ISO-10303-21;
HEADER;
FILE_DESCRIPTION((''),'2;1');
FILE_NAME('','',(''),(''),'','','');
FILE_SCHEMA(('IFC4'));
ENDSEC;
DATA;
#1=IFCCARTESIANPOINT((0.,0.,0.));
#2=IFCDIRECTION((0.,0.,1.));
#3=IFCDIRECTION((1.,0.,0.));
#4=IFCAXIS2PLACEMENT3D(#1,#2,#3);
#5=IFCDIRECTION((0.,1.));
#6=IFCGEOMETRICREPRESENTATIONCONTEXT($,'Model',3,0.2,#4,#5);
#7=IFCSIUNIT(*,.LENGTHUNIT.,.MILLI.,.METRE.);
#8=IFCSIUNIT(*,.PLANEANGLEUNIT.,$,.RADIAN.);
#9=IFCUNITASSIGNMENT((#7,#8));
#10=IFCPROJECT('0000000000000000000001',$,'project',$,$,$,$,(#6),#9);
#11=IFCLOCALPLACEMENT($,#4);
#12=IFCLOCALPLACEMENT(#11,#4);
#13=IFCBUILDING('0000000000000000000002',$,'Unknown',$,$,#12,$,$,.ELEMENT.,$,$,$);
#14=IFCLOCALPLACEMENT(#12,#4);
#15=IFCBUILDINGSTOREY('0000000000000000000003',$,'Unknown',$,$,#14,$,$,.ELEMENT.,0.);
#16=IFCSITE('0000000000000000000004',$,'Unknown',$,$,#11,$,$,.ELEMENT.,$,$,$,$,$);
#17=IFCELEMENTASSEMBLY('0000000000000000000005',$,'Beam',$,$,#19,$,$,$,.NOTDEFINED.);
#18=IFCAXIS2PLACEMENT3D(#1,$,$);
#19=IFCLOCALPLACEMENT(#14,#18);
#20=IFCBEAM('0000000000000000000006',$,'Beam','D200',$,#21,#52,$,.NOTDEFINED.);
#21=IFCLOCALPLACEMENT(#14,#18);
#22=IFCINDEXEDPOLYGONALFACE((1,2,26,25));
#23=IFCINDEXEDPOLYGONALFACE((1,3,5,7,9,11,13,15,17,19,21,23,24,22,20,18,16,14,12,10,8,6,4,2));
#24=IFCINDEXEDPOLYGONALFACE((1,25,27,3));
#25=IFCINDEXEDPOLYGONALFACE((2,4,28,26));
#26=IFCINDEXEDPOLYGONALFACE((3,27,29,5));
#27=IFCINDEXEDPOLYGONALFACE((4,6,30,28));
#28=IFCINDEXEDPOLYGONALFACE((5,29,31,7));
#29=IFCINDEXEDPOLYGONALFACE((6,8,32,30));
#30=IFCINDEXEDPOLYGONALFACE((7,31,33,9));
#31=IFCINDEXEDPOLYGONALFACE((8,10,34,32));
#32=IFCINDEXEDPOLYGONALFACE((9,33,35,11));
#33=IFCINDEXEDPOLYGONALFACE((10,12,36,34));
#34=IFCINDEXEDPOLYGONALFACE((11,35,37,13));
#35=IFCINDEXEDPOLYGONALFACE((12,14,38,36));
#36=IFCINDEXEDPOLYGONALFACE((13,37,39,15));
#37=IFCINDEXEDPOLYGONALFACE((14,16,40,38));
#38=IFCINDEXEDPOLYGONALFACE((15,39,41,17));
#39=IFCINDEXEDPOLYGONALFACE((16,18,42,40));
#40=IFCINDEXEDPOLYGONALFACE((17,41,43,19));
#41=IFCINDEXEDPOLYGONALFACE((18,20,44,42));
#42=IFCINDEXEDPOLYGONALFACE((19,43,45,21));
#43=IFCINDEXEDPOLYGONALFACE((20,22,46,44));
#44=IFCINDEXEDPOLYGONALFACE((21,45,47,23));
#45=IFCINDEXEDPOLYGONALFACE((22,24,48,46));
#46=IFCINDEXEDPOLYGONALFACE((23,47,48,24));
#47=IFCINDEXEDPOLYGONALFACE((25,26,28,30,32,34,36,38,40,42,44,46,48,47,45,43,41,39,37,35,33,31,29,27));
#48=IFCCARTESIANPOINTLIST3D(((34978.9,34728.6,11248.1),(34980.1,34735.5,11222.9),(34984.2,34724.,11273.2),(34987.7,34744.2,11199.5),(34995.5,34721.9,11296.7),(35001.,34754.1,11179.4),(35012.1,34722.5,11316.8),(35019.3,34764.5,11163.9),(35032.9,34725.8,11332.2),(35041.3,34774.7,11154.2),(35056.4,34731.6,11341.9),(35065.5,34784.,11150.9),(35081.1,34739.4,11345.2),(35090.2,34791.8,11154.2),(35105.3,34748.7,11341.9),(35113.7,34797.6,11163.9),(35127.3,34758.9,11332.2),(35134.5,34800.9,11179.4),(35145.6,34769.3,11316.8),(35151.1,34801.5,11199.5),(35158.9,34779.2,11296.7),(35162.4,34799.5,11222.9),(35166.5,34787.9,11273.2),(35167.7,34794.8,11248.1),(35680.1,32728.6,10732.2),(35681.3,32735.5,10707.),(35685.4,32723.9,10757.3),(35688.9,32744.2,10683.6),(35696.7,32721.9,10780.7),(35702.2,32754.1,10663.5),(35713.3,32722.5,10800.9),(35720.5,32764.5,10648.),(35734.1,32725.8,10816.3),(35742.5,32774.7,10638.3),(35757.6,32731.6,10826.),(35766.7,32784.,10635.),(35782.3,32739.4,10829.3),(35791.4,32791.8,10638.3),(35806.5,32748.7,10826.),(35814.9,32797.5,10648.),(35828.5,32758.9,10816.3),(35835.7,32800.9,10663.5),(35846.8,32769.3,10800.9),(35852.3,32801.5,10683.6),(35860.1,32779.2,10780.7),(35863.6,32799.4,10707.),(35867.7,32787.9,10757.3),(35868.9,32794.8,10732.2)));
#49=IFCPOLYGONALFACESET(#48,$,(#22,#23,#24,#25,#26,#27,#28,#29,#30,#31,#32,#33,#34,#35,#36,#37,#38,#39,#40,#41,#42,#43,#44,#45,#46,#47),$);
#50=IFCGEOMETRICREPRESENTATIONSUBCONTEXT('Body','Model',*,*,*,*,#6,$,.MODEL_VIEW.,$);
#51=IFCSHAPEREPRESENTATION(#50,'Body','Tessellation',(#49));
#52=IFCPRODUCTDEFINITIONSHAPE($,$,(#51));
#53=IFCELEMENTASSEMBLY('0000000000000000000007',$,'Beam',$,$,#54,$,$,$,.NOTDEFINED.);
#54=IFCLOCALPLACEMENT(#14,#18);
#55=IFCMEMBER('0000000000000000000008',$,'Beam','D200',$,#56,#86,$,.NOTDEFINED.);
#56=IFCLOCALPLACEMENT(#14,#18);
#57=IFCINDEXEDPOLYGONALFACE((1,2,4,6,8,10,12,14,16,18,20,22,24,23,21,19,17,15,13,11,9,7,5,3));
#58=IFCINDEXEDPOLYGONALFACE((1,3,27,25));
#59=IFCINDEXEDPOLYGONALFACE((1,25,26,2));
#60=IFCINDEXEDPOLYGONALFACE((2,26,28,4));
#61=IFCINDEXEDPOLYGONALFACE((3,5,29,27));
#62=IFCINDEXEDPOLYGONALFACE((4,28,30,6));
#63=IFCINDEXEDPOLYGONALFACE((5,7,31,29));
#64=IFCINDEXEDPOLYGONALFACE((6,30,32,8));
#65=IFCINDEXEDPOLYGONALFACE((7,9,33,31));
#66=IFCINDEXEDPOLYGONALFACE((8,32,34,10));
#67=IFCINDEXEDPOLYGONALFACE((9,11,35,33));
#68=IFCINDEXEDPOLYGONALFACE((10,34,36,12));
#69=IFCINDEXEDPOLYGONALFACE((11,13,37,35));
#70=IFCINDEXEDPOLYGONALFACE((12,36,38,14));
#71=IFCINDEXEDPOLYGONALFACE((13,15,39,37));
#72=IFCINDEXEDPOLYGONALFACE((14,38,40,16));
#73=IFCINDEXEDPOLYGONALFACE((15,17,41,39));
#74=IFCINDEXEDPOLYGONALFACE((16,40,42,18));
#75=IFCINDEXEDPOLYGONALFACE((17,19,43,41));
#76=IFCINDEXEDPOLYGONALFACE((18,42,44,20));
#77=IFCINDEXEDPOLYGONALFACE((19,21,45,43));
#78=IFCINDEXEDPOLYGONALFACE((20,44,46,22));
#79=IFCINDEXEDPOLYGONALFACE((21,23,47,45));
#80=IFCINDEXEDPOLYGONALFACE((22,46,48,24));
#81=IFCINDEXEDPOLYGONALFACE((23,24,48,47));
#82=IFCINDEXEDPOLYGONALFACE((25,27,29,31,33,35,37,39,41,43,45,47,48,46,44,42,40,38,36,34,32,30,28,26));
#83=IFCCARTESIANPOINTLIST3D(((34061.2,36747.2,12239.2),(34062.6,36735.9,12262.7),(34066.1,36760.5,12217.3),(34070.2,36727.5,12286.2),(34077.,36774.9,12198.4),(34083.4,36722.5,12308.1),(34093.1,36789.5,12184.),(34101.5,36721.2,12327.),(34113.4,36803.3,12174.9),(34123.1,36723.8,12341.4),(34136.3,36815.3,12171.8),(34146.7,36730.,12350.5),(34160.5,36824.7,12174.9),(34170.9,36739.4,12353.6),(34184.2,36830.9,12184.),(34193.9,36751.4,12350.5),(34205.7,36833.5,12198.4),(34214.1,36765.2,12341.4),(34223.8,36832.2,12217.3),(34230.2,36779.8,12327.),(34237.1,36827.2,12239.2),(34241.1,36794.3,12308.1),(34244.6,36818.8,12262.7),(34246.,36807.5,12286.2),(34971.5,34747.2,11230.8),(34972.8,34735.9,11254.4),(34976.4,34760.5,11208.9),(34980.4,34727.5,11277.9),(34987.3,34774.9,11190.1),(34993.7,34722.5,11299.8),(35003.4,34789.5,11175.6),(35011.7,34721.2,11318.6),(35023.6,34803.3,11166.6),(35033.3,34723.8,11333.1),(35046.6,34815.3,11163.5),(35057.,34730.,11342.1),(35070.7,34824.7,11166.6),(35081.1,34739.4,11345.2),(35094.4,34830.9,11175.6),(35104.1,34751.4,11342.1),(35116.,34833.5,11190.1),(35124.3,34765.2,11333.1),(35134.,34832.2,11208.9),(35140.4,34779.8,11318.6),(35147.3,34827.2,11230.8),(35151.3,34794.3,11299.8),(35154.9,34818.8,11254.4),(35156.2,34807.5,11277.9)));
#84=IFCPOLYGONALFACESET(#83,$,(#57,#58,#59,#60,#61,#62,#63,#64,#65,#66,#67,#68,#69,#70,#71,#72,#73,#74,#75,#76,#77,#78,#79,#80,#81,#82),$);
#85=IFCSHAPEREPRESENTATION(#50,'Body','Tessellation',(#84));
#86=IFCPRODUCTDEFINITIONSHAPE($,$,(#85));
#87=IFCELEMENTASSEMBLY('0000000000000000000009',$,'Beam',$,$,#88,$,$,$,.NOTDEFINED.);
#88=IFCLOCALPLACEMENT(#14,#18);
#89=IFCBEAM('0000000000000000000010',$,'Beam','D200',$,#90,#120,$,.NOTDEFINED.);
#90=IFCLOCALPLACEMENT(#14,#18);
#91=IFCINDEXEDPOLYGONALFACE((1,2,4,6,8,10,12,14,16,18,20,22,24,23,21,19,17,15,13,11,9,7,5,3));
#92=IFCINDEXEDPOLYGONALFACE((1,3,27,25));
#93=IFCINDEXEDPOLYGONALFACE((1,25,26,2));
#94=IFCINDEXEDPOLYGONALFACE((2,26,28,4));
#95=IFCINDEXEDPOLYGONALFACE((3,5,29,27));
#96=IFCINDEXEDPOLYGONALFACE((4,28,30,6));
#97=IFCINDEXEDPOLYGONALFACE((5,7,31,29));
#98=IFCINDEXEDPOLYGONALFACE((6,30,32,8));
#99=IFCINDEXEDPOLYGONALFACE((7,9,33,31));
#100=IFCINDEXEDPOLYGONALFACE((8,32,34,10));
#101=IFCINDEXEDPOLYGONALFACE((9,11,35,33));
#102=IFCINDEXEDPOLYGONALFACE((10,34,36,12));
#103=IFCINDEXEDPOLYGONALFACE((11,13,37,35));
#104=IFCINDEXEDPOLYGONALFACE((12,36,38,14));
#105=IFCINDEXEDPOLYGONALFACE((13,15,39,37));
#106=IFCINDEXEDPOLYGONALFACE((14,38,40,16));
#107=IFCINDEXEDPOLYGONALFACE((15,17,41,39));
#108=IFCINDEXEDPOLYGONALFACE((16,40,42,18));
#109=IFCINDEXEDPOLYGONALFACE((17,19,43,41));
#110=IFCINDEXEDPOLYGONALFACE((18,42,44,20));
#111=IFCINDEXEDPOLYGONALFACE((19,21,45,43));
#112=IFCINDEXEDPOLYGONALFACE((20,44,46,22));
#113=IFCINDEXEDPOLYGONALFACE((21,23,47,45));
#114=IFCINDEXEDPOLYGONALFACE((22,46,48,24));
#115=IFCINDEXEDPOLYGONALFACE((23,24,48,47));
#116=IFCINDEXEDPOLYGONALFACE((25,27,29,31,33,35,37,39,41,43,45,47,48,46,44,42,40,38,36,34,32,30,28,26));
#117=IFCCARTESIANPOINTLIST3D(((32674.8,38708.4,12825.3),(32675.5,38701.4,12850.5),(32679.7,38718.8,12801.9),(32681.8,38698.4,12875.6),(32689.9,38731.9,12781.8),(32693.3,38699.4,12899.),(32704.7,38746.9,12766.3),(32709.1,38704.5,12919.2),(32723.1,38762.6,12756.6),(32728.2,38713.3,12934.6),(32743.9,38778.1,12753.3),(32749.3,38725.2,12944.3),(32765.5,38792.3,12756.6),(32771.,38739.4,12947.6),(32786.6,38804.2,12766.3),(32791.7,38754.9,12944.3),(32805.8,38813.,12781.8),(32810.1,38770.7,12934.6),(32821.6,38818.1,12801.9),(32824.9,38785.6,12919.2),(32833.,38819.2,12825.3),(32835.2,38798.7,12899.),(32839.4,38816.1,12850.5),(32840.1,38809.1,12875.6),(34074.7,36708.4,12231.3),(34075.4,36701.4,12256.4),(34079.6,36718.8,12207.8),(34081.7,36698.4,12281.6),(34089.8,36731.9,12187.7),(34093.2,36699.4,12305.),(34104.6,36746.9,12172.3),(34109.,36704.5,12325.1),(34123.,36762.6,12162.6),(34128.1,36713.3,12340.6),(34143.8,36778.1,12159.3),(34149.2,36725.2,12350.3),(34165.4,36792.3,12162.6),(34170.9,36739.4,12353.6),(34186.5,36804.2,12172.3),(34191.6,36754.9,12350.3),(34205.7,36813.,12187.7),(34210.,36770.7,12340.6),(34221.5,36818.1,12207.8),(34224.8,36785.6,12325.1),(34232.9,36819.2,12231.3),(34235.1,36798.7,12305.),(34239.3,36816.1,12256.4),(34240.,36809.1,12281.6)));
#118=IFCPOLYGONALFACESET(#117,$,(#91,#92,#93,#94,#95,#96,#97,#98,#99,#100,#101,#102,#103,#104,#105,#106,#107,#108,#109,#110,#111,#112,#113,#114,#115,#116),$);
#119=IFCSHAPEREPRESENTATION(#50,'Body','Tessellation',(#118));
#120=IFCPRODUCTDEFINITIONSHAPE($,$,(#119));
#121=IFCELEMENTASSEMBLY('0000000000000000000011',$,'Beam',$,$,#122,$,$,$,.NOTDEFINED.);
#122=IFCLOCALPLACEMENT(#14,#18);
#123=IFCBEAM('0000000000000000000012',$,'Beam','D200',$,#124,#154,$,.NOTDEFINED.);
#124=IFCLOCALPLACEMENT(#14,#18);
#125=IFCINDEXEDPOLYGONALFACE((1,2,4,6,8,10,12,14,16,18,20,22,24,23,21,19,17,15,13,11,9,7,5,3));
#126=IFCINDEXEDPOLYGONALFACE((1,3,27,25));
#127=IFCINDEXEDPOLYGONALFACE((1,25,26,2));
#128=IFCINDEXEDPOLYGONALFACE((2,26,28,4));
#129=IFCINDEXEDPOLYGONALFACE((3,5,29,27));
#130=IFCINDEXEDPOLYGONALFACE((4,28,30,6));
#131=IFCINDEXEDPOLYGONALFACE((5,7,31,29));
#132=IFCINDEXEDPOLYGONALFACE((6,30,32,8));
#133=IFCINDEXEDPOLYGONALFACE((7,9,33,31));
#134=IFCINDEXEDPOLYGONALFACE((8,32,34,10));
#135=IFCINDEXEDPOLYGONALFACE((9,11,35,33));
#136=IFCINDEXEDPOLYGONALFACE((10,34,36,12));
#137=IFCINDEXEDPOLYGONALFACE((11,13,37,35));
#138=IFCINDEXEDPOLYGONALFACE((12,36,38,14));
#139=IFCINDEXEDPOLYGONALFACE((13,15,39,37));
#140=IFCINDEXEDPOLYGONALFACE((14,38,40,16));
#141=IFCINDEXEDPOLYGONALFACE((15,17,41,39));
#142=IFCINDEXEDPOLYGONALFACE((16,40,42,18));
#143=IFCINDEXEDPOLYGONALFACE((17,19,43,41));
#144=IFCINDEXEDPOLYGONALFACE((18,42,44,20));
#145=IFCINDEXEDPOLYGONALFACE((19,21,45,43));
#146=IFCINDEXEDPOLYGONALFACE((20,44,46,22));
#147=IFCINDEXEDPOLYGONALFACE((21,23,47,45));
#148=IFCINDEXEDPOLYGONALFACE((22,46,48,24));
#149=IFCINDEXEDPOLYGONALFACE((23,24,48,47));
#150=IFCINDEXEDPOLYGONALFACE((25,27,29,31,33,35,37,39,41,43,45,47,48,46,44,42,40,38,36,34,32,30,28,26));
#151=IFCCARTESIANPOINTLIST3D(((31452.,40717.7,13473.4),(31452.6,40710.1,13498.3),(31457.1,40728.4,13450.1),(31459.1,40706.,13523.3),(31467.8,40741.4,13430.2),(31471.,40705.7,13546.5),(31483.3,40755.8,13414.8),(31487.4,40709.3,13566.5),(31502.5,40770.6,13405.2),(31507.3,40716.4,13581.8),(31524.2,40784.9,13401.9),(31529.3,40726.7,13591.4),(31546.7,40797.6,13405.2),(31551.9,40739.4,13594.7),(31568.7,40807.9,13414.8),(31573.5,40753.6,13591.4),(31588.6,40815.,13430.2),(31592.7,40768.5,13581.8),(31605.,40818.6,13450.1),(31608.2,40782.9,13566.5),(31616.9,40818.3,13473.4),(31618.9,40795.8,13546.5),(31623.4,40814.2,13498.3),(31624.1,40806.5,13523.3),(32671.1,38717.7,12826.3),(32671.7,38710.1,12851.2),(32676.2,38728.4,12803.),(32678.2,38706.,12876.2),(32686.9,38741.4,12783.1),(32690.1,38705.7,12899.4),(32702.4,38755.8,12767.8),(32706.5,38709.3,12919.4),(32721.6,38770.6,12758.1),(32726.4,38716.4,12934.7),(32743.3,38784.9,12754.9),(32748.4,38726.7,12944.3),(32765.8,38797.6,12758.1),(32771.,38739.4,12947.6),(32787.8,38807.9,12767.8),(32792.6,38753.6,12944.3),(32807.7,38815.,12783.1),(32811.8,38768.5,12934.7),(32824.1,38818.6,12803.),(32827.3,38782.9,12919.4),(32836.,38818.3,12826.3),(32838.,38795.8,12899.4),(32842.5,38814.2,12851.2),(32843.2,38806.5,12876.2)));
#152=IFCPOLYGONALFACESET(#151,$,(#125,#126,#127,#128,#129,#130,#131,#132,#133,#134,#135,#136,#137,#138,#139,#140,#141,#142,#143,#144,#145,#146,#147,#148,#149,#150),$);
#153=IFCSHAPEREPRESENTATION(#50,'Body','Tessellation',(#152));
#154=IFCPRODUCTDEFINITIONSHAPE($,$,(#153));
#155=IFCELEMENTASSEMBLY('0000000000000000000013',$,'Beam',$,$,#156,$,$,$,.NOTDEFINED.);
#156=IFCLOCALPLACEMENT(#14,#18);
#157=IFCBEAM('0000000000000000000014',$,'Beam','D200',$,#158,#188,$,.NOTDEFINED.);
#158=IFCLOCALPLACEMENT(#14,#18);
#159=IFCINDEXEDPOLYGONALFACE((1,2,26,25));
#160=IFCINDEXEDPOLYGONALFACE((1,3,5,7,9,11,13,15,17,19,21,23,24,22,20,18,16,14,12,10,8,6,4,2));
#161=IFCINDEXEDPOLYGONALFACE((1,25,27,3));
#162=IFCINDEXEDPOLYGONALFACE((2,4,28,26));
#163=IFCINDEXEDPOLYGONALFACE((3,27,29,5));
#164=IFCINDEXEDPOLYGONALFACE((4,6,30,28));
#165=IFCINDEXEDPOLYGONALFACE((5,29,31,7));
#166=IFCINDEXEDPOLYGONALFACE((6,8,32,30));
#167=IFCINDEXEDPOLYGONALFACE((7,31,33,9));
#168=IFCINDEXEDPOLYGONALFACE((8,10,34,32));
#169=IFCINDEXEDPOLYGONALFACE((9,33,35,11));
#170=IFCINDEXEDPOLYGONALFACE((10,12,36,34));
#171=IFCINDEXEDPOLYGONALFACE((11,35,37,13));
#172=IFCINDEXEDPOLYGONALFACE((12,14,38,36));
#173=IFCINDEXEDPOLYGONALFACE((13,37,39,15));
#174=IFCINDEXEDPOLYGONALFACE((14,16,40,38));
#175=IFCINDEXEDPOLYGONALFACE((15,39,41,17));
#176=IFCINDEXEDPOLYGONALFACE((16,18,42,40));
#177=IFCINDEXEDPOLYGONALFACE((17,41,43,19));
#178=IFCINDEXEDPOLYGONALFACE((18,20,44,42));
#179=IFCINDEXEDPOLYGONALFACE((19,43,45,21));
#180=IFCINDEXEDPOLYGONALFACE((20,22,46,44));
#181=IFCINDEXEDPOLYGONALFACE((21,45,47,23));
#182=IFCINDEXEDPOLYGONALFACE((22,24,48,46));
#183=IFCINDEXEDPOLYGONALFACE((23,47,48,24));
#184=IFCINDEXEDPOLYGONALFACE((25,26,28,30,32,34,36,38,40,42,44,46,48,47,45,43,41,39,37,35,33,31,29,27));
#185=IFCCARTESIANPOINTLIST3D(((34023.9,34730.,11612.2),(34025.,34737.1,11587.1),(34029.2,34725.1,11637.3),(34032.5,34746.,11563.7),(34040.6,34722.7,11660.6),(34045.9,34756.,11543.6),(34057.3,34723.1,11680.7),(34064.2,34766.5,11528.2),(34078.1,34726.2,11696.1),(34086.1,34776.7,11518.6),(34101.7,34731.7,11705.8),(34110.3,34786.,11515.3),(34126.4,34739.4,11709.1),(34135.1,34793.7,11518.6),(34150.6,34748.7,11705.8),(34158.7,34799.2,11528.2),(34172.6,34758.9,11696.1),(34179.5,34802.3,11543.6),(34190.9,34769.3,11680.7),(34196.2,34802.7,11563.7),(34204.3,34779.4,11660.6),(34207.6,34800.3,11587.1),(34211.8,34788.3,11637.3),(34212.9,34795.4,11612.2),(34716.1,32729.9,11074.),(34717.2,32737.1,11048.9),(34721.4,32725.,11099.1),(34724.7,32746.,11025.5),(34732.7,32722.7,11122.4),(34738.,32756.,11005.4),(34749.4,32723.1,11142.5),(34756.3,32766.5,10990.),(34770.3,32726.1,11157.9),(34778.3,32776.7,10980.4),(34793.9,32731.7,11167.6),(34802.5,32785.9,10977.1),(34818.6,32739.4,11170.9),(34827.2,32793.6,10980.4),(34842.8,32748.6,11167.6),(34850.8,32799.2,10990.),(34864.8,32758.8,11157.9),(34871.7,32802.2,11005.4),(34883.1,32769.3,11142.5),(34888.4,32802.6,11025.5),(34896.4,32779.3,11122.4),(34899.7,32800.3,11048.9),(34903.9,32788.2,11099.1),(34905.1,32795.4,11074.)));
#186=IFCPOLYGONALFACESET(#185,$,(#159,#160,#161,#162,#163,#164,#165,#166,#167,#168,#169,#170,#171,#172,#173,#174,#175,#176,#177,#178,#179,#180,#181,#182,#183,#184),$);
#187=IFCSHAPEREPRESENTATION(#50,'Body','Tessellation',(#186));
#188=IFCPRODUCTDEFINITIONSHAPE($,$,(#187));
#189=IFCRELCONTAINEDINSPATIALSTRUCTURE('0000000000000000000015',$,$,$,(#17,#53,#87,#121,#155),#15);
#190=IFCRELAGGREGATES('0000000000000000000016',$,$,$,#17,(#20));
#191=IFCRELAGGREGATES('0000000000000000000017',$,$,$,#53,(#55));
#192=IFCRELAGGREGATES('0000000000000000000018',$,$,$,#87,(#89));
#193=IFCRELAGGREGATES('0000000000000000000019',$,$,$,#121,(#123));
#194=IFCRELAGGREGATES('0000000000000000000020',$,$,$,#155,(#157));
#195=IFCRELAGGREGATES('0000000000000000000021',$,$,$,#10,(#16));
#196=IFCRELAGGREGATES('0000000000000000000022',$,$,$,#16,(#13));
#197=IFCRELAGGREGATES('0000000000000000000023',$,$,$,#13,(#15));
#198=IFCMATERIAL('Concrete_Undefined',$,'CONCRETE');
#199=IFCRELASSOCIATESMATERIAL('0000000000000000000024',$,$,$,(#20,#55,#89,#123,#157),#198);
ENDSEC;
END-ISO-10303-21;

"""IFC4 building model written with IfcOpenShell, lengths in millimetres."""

from ifc_helpers import new_model, si_unit, direction, frame, origin_with_axes, place, context, subcontext, project, spatial, line, indexed_curve, outline, extrude, material, element, aggregate, save


model = new_model("IFC4")

# Units and contexts
model_context = context("Model", 3, precision=0.2, world=origin_with_axes(), true_north=direction((0.0, 1.0)))
body_context = subcontext(model_context, "Body", "Model", "MODEL_VIEW")
ifc_project = project(units=[si_unit("LENGTHUNIT", "METRE", prefix="MILLI"), si_unit("PLANEANGLEUNIT", "RADIAN")], contexts=[model_context])

# Site, building, storey
site_placement = place(None, origin_with_axes())
site = spatial("IfcSite", under=ifc_project, at=site_placement, Name="Unknown", CompositionType="ELEMENT")
building_placement = place(site_placement, origin_with_axes())
building = spatial("IfcBuilding", under=site, at=building_placement, Name="Unknown", CompositionType="ELEMENT")
storey_placement = place(building_placement, origin_with_axes())
storey = spatial("IfcBuildingStorey", under=building, at=storey_placement, Name="Unknown", CompositionType="ELEMENT", Elevation=0.0)

# Shared definitions
ifc_material = material(Name="Concrete_Undefined", Category="CONCRETE")

# Element assembly, beam
assembly_1_placement = place(storey_placement, frame((35073.3, 34761.7, 11248.1), z_axis=(-0.943682, -0.330854, 0.0), x_axis=(0.321466, -0.916907, -0.236519)))
assembly_1 = element("IfcElementAssembly", 1, at=assembly_1_placement, inside=storey, Name="Beam", PredefinedType="NOTDEFINED")
beam_1_placement = place(assembly_1_placement, origin_with_axes())
beam_1 = element("IfcBeam", 2, at=beam_1_placement, material=ifc_material, Name="Beam", Description="D200", PredefinedType="NOTDEFINED", context=body_context, shape_type="SolidModel", body=[
    extrude(outline(indexed_curve([(100.0, 0.0), (96.6, 25.9), (86.6, 50.0), (70.7, 70.7), (50.0, 86.6), (25.9, 96.6), (0.0, 100.0), (-25.9, 96.6), (-50.0, 86.6), (-70.7, 70.7), (-86.6, 50.0), (-96.6, 25.9), (-100.0, 0.0), (-96.6, -25.9), (-86.6, -50.0), (-70.7, -70.7), (-50.0, -86.6), (-25.9, -96.6), (0.0, -100.0), (25.9, -96.6), (50.0, -86.6), (70.7, -70.7), (86.6, -50.0), (96.6, -25.9)], segments=[line(1, 2, 3, 4, 5, 6, 7, 8, 9, 10, 11, 12, 13, 14, 15, 16, 17, 18, 19, 20, 21, 22, 23, 24, 1)])), frame((0.0, 0.0, 0.0), z_axis=(-1.0, 0.0, 0.0), x_axis=(0.0, 0.0, 1.0)), (0.0, 0.0, -1.0), 2181.3),
])
aggregate(assembly_1, [beam_1])

# Element assembly, member
assembly_2_placement = place(storey_placement, frame((34153.6, 36777.4, 12262.7), z_axis=(-0.91017, -0.414234, 0.0), x_axis=(0.376487, -0.827231, -0.417069)))
assembly_2 = element("IfcElementAssembly", 3, at=assembly_2_placement, inside=storey, Name="Beam", PredefinedType="NOTDEFINED")
member_1_placement = place(assembly_2_placement, origin_with_axes())
member_1 = element("IfcMember", 4, at=member_1_placement, material=ifc_material, Name="Beam", Description="D200", PredefinedType="NOTDEFINED", context=body_context, shape_type="SolidModel", body=[
    extrude(outline(indexed_curve([(100.0, 0.0), (96.6, 25.9), (86.6, 50.0), (70.7, 70.7), (50.0, 86.6), (25.9, 96.6), (0.0, 100.0), (-25.9, 96.6), (-50.0, 86.6), (-70.7, 70.7), (-86.6, 50.0), (-96.6, 25.9), (-100.0, 0.0), (-96.6, -25.9), (-86.6, -50.0), (-70.7, -70.7), (-50.0, -86.6), (-25.9, -96.6), (0.0, -100.0), (25.9, -96.6), (50.0, -86.6), (70.7, -70.7), (86.6, -50.0), (96.6, -25.9)], segments=[line(1, 2, 3, 4, 5, 6, 7, 8, 9, 10, 11, 12, 13, 14, 15, 16, 17, 18, 19, 20, 21, 22, 23, 24, 1)])), frame((0.0, 0.0, 0.0), z_axis=(-1.0, 0.0, 0.0), x_axis=(0.0, 0.0, 1.0)), (0.0, 0.0, -1.0), 2417.7),
])
aggregate(assembly_2, [member_1])

# Element assemblies, beams
assembly_3_placement = place(storey_placement, frame((32757.4, 38758.8, 12850.5), z_axis=(-0.819251, -0.573435, 0.0), x_axis=(0.557177, -0.796023, -0.236434)))
assembly_3 = element("IfcElementAssembly", 5, at=assembly_3_placement, inside=storey, Name="Beam", PredefinedType="NOTDEFINED")
beam_2_placement = place(assembly_3_placement, origin_with_axes())
beam_2 = element("IfcBeam", 6, at=beam_2_placement, material=ifc_material, Name="Beam", Description="D200", PredefinedType="NOTDEFINED", context=body_context, shape_type="SolidModel", body=[
    extrude(outline(indexed_curve([(100.0, 0.0), (96.6, 25.9), (86.6, 50.0), (70.7, 70.7), (50.0, 86.6), (25.9, 96.6), (0.0, 100.0), (-25.9, 96.6), (-50.0, 86.6), (-70.7, 70.7), (-86.6, 50.0), (-96.6, 25.9), (-100.0, 0.0), (-96.6, -25.9), (-86.6, -50.0), (-70.7, -70.7), (-50.0, -86.6), (-25.9, -96.6), (0.0, -100.0), (25.9, -96.6), (50.0, -86.6), (70.7, -70.7), (86.6, -50.0), (96.6, -25.9)], segments=[line(1, 2, 3, 4, 5, 6, 7, 8, 9, 10, 11, 12, 13, 14, 15, 16, 17, 18, 19, 20, 21, 22, 23, 24, 1)])), frame((0.0, 0.0, 0.0), z_axis=(-1.0, 0.0, 0.0), x_axis=(0.0, 0.0, 1.0)), (0.0, 0.0, -1.0), 2512.5),
])
aggregate(assembly_3, [beam_2])
assembly_4_placement = place(storey_placement, frame((31538.0, 40762.1, 13498.3), z_axis=(-0.853874, -0.520479, 0.0), x_axis=(0.501687, -0.823045, -0.266282)))
assembly_4 = element("IfcElementAssembly", 7, at=assembly_4_placement, inside=storey, Name="Beam", PredefinedType="NOTDEFINED")
beam_3_placement = place(assembly_4_placement, origin_with_axes())
beam_3 = element("IfcBeam", 8, at=beam_3_placement, material=ifc_material, Name="Beam", Description="D200", PredefinedType="NOTDEFINED", context=body_context, shape_type="SolidModel", body=[
    extrude(outline(indexed_curve([(100.0, 0.0), (96.6, 25.9), (86.6, 50.0), (70.7, 70.7), (50.0, 86.6), (25.9, 96.6), (0.0, 100.0), (-25.9, 96.6), (-50.0, 86.6), (-70.7, 70.7), (-86.6, 50.0), (-96.6, 25.9), (-100.0, 0.0), (-96.6, -25.9), (-86.6, -50.0), (-70.7, -70.7), (-50.0, -86.6), (-25.9, -96.6), (0.0, -100.0), (25.9, -96.6), (50.0, -86.6), (70.7, -70.7), (86.6, -50.0), (96.6, -25.9)], segments=[line(1, 2, 3, 4, 5, 6, 7, 8, 9, 10, 11, 12, 13, 14, 15, 16, 17, 18, 19, 20, 21, 22, 23, 24, 1)])), frame((0.0, 0.0, 0.0), z_axis=(-1.0, 0.0, 0.0), x_axis=(0.0, 0.0, 1.0)), (0.0, 0.0, -1.0), 2430.0),
])
aggregate(assembly_4, [beam_3])
assembly_5_placement = place(storey_placement, frame((34118.4, 34762.7, 11612.2), z_axis=(-0.945008, -0.327046, 0.0), x_axis=(0.316958, -0.915858, -0.246457)))
assembly_5 = element("IfcElementAssembly", 9, at=assembly_5_placement, inside=storey, Name="Beam", PredefinedType="NOTDEFINED")
beam_4_placement = place(assembly_5_placement, origin_with_axes())
beam_4 = element("IfcBeam", 10, at=beam_4_placement, material=ifc_material, Name="Beam", Description="D200", PredefinedType="NOTDEFINED", context=body_context, shape_type="SolidModel", body=[
    extrude(outline(indexed_curve([(100.0, 0.0), (96.6, 25.9), (86.6, 50.0), (70.7, 70.7), (50.0, 86.6), (25.9, 96.6), (0.0, 100.0), (-25.9, 96.6), (-50.0, 86.6), (-70.7, 70.7), (-86.6, 50.0), (-96.6, 25.9), (-100.0, 0.0), (-96.6, -25.9), (-86.6, -50.0), (-70.7, -70.7), (-50.0, -86.6), (-25.9, -96.6), (0.0, -100.0), (25.9, -96.6), (50.0, -86.6), (70.7, -70.7), (86.6, -50.0), (96.6, -25.9)], segments=[line(1, 2, 3, 4, 5, 6, 7, 8, 9, 10, 11, 12, 13, 14, 15, 16, 17, 18, 19, 20, 21, 22, 23, 24, 1)])), frame((0.0, 0.0, 0.0), z_axis=(-1.0, 0.0, 0.0), x_axis=(0.0, 0.0, 1.0)), (0.0, 0.0, -1.0), 2183.8),
])
aggregate(assembly_5, [beam_4])

save(model, "model.ifc")
